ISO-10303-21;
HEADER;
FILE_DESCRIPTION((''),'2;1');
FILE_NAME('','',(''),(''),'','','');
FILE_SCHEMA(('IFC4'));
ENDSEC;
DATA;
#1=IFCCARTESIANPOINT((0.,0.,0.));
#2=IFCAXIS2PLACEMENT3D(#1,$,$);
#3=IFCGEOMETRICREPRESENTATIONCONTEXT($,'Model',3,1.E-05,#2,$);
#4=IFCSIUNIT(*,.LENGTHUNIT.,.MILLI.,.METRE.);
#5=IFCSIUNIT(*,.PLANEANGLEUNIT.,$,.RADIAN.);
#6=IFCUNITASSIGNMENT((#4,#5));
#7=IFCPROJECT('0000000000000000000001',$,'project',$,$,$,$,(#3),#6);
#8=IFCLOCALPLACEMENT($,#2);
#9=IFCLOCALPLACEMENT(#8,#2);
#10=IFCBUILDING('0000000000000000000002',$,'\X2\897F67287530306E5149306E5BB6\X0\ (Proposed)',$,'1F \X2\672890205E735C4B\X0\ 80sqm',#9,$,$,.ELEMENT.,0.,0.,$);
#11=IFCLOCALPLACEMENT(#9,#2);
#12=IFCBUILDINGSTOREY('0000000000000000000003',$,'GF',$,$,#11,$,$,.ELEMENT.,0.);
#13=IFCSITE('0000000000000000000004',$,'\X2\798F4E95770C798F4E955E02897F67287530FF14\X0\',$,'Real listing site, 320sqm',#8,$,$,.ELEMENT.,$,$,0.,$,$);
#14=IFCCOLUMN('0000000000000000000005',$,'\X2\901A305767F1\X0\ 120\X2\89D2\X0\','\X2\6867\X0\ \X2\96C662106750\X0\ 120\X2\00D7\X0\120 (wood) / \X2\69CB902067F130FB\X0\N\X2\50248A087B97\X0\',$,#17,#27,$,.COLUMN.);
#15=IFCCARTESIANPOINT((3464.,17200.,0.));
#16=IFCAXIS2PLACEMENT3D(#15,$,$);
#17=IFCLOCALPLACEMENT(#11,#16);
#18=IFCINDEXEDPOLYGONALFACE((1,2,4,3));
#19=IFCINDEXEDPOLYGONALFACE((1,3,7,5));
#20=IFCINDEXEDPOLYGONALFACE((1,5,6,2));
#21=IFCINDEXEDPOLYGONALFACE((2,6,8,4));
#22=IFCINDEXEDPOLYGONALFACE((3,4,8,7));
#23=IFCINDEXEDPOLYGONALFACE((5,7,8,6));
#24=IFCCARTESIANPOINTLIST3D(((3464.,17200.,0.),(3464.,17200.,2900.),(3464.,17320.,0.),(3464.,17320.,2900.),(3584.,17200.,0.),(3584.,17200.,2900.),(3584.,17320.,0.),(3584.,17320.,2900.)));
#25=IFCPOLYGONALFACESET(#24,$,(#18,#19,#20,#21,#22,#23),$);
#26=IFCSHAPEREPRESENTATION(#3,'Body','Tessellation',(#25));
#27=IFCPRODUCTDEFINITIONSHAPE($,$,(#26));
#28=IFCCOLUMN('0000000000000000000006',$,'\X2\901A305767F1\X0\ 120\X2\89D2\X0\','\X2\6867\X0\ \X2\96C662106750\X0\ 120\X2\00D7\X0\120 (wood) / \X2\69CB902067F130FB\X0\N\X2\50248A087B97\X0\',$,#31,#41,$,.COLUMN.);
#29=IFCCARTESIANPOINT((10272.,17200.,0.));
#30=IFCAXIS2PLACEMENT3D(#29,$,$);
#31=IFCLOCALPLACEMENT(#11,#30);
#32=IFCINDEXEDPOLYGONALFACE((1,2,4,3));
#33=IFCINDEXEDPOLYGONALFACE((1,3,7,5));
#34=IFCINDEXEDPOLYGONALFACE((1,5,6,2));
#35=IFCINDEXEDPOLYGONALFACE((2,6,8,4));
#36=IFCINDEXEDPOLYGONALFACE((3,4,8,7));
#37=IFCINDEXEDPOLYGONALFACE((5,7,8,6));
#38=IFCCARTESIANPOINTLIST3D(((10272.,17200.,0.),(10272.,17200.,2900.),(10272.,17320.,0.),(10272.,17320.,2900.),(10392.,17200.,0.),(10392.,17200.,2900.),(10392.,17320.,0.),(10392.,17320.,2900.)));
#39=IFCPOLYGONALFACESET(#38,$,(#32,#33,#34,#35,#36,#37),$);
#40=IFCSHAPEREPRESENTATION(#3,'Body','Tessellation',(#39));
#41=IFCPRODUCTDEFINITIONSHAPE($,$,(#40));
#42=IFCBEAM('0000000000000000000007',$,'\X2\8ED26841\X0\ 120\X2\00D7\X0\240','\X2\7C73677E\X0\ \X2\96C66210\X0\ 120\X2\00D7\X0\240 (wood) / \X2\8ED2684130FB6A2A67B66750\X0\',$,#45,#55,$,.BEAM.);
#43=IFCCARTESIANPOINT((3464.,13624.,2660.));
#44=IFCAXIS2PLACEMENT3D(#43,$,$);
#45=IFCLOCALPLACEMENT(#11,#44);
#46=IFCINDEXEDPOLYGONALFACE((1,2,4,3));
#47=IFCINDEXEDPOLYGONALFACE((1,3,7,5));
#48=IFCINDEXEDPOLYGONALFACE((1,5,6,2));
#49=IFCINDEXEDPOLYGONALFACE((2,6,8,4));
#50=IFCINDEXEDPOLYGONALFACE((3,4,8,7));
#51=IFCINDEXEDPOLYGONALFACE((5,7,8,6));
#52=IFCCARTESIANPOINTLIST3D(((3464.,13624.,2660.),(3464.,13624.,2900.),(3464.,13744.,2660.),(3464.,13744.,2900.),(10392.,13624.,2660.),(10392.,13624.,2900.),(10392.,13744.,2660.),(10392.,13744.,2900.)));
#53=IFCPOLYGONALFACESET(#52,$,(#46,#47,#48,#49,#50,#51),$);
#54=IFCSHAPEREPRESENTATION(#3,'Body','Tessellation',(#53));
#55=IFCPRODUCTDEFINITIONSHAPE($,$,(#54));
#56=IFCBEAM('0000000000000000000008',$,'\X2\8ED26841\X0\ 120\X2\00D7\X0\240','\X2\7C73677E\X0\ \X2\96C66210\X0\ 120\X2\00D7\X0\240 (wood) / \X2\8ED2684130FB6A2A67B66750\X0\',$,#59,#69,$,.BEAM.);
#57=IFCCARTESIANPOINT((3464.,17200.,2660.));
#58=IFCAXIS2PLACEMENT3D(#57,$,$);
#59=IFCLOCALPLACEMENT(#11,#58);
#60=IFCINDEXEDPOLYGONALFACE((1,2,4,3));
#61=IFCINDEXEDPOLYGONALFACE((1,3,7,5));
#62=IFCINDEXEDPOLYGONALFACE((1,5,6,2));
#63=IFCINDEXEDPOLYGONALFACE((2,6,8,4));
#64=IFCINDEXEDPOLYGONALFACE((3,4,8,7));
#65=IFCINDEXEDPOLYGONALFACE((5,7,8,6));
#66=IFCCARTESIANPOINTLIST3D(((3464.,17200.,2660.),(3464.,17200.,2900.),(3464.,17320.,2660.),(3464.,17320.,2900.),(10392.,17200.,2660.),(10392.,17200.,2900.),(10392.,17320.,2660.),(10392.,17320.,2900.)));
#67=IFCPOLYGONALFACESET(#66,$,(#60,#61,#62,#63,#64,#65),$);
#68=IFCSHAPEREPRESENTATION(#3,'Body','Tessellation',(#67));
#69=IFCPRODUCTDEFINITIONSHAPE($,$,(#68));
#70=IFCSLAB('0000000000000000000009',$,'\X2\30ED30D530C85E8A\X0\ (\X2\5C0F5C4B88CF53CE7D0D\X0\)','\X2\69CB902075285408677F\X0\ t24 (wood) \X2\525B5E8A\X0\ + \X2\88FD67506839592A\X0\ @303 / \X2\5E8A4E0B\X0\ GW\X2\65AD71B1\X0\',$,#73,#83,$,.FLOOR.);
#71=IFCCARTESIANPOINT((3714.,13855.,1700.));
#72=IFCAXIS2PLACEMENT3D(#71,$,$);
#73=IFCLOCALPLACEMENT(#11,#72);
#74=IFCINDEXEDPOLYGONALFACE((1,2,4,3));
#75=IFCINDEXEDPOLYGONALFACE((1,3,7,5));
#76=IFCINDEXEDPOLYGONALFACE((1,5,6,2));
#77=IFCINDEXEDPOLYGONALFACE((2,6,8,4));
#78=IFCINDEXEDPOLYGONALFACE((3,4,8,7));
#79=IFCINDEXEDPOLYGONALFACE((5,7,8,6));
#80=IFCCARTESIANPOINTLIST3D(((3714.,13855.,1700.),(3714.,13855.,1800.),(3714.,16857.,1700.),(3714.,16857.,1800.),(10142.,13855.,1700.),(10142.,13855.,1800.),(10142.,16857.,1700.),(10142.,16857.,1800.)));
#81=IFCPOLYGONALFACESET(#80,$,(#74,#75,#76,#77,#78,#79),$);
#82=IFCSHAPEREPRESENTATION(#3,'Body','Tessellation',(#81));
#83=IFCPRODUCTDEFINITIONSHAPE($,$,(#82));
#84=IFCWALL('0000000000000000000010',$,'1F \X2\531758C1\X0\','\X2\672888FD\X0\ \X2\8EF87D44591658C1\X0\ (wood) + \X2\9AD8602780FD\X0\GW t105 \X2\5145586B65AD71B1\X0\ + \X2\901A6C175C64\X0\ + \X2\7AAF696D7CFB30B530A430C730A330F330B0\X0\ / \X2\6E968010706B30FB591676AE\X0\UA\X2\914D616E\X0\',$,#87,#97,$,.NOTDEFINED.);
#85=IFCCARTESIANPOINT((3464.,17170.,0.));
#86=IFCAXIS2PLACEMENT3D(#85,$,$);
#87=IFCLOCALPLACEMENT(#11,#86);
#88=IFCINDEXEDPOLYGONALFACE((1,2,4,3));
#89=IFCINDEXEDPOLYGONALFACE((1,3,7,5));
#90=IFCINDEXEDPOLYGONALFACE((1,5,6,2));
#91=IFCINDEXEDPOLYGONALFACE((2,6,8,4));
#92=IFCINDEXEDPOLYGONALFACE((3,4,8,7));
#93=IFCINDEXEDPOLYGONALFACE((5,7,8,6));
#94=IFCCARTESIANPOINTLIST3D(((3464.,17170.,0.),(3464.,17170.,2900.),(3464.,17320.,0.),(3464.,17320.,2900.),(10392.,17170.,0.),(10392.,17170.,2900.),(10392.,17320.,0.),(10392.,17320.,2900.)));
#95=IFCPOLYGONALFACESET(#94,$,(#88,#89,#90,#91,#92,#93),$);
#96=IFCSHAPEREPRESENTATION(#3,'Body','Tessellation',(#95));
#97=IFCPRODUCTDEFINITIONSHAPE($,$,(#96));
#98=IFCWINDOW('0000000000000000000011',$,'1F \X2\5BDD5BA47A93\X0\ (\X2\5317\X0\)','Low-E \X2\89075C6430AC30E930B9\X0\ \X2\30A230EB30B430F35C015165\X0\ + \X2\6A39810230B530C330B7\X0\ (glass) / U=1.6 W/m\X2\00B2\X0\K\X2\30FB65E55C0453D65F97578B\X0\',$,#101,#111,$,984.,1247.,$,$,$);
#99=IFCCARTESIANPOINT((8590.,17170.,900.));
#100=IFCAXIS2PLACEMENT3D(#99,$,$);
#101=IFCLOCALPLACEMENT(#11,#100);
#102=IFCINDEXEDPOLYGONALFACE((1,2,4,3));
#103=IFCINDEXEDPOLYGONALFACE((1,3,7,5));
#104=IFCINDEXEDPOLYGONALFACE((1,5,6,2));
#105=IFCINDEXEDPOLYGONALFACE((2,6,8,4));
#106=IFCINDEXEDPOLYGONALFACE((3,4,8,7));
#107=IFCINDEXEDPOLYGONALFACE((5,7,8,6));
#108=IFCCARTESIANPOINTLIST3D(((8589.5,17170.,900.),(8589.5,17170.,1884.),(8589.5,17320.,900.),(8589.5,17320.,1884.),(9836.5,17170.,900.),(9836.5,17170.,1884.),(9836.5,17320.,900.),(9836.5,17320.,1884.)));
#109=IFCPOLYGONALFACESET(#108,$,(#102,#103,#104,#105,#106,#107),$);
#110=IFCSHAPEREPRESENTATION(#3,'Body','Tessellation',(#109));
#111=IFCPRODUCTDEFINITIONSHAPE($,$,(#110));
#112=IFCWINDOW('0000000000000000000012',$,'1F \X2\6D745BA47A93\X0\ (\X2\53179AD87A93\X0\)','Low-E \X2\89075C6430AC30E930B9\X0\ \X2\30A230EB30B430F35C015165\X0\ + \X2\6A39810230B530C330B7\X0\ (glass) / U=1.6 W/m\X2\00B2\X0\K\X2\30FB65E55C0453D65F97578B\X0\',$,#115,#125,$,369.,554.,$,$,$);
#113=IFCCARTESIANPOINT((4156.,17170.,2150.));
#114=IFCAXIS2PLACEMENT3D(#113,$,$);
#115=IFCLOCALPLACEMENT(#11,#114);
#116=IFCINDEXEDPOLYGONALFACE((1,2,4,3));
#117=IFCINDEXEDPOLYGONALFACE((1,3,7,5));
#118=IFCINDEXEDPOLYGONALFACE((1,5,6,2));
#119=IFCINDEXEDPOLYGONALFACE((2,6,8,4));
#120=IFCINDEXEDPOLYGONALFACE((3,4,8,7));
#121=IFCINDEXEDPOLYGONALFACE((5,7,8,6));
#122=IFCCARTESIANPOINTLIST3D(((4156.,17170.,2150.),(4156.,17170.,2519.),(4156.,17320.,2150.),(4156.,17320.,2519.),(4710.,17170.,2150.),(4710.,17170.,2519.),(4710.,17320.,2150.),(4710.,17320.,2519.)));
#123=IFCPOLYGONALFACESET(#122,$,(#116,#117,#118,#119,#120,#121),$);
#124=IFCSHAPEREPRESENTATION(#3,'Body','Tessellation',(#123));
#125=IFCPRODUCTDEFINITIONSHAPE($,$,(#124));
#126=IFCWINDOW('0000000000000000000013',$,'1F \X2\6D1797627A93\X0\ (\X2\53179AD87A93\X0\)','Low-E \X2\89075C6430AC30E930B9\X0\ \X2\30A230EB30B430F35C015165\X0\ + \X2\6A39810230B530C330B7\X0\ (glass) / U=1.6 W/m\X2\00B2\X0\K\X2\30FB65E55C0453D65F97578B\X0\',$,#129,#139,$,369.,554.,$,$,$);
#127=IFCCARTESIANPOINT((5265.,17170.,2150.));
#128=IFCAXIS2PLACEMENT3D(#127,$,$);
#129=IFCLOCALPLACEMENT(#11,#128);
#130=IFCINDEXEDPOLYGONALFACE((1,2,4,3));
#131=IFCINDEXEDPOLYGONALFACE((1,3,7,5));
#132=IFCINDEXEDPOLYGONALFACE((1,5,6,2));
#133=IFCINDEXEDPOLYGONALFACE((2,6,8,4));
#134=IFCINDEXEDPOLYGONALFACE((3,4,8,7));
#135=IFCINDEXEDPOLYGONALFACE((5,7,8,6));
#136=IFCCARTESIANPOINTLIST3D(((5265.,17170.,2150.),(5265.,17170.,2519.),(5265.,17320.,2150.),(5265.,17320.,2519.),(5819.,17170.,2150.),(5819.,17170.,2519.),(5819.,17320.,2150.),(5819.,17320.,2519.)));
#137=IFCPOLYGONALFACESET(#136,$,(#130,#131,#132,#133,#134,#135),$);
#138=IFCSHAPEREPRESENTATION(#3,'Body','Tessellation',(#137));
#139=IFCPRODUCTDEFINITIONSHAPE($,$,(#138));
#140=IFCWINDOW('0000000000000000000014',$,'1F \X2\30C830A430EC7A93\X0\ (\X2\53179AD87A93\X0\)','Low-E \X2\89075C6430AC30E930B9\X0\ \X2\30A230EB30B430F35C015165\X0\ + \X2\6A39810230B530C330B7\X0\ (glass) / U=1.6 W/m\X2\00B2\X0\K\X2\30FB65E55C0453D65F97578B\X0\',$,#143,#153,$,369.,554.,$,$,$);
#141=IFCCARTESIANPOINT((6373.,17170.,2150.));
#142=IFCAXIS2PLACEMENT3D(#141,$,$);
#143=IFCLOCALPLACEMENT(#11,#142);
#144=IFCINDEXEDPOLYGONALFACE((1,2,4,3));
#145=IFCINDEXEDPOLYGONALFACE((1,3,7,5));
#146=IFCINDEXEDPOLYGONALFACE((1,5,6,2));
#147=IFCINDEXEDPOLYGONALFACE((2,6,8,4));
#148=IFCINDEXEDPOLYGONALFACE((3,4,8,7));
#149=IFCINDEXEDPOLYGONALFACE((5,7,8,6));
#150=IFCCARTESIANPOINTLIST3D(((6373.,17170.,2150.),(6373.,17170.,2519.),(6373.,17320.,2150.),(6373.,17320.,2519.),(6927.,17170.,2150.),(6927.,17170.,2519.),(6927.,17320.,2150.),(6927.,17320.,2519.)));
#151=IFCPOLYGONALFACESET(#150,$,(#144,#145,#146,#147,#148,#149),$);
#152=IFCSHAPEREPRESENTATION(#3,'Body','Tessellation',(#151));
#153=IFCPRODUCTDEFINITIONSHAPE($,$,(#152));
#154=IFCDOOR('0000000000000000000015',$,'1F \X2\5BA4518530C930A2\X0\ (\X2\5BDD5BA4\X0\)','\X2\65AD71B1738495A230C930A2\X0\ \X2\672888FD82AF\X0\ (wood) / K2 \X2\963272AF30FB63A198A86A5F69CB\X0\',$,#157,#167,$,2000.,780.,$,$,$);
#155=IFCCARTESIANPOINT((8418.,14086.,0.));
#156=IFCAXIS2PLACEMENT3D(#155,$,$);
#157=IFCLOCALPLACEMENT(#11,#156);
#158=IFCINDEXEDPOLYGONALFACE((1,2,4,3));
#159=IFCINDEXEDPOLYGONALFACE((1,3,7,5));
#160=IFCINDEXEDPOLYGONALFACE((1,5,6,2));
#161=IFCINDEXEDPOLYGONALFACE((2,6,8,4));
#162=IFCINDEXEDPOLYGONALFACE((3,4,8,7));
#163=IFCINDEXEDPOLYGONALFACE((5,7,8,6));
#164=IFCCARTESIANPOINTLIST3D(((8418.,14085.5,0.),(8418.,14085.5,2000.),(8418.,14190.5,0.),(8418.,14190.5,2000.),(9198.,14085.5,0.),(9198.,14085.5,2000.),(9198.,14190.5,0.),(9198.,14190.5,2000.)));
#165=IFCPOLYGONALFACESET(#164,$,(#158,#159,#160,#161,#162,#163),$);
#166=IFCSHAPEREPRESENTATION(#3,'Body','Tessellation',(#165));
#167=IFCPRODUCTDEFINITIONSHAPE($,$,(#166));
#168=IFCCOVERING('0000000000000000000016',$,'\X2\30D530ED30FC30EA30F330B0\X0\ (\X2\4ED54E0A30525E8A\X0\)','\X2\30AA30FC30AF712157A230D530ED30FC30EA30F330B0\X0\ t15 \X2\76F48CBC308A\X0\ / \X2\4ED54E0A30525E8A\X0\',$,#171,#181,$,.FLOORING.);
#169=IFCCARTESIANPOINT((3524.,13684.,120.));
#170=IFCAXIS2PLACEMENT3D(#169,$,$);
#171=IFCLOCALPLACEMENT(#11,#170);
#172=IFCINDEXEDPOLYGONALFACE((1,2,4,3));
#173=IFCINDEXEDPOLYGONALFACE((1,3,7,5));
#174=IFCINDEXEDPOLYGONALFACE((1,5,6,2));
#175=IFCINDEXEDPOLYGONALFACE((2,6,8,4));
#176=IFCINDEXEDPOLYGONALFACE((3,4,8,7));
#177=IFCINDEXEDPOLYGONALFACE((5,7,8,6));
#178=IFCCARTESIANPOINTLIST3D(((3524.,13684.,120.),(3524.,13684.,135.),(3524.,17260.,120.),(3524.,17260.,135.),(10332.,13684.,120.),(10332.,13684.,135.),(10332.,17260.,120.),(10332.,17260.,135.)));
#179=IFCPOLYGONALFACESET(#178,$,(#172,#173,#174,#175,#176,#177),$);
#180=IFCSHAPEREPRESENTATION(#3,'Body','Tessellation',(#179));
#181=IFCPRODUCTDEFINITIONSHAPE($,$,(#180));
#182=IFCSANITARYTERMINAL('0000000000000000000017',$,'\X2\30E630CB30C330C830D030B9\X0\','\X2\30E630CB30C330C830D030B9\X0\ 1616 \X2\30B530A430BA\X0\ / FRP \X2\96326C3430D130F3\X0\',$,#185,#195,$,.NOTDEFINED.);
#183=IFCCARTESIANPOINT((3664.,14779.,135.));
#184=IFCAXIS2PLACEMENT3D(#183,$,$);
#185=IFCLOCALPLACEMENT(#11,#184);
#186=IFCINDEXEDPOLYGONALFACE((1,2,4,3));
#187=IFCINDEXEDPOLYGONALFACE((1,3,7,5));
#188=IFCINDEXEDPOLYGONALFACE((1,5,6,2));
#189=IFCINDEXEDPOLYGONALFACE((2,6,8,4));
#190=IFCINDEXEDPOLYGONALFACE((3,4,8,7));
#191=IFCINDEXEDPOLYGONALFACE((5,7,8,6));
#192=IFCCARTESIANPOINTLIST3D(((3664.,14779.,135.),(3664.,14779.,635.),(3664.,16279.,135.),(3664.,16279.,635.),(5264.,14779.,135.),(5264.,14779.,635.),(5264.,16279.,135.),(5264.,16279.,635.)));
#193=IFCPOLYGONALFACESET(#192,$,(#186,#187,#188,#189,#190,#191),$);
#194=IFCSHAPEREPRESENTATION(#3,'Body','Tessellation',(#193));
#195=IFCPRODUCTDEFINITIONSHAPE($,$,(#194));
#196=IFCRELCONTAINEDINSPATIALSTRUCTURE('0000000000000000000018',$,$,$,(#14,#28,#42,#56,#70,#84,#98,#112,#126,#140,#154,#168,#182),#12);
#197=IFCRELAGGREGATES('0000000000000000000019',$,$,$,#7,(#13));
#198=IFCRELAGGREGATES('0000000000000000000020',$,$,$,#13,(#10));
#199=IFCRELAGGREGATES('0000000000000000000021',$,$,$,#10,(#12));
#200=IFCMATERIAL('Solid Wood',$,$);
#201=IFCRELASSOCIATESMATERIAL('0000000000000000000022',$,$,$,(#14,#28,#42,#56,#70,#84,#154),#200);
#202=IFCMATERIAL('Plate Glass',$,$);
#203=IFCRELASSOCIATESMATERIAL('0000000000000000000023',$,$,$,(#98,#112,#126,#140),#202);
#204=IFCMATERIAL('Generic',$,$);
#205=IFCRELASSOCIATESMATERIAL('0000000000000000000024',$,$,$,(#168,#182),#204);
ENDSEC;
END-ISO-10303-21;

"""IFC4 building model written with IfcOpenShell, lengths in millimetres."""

from ifc_helpers import new_model, si_unit, frame, frame_2d, origin, place, context, project, spatial, rectangle, extrude, material, element, fill, save


model = new_model("IFC4")

# Units and contexts
model_context = context("Model", 3, precision=1e-05, world=origin())
ifc_project = project(units=[si_unit("LENGTHUNIT", "METRE", prefix="MILLI"), si_unit("PLANEANGLEUNIT", "RADIAN")], contexts=[model_context])

# Site, building, storey
site_placement = place(None, origin())
site = spatial("IfcSite", under=ifc_project, at=site_placement, Name="福井県福井市西木田４", ObjectType="Real listing site, 320sqm", CompositionType="ELEMENT", RefElevation=0.0)
building_placement = place(site_placement, origin())
building = spatial("IfcBuilding", under=site, at=building_placement, Name="西木田の光の家 (Proposed)", ObjectType="1F 木造平屋 80sqm", CompositionType="ELEMENT", ElevationOfRefHeight=0.0, ElevationOfTerrain=0.0)
storey_placement = place(building_placement, origin())
storey = spatial("IfcBuildingStorey", under=building, at=storey_placement, Name="GF", CompositionType="ELEMENT", Elevation=0.0)

# Columns
ifc_material_1 = material(Name="Solid Wood")
column_1_placement = place(storey_placement, frame((3464.0, 17200.0, 0.0)))
element("IfcColumn", 1, at=column_1_placement, inside=storey, material=ifc_material_1, Name="通し柱 120角", Description="桧 集成材 120×120 (wood) / 構造柱・N値計算", PredefinedType="COLUMN", context=model_context, shape_type="SweptSolid", body=[
    extrude(rectangle(XDim=120.0, YDim=120.0, at=frame_2d((60.0, 60.0))), frame((3464.0, 17200.0, 0.0)), (0.0, 0.0, 1.0), 2900.0),
])
column_2_placement = place(storey_placement, frame((10272.0, 17200.0, 0.0)))
element("IfcColumn", 2, at=column_2_placement, inside=storey, material=ifc_material_1, Name="通し柱 120角", Description="桧 集成材 120×120 (wood) / 構造柱・N値計算", PredefinedType="COLUMN", context=model_context, shape_type="SweptSolid", body=[
    extrude(rectangle(XDim=120.0, YDim=120.0, at=frame_2d((60.0, 60.0))), frame((10272.0, 17200.0, 0.0)), (0.0, 0.0, 1.0), 2900.0),
])

# Beams
beam_1_placement = place(storey_placement, frame((3464.0, 13624.0, 2660.0)))
element("IfcBeam", 3, at=beam_1_placement, inside=storey, material=ifc_material_1, Name="軒桁 120×240", Description="米松 集成 120×240 (wood) / 軒桁・横架材", PredefinedType="BEAM", context=model_context, shape_type="SweptSolid", body=[
    extrude(rectangle(XDim=6928.0, YDim=120.0, at=frame_2d((3464.0, 60.0))), frame((3464.0, 13624.0, 2660.0)), (0.0, 0.0, 1.0), 240.0),
])
beam_2_placement = place(storey_placement, frame((3464.0, 17200.0, 2660.0)))
element("IfcBeam", 4, at=beam_2_placement, inside=storey, material=ifc_material_1, Name="軒桁 120×240", Description="米松 集成 120×240 (wood) / 軒桁・横架材", PredefinedType="BEAM", context=model_context, shape_type="SweptSolid", body=[
    extrude(rectangle(XDim=6928.0, YDim=120.0, at=frame_2d((3464.0, 60.0))), frame((3464.0, 17200.0, 2660.0)), (0.0, 0.0, 1.0), 240.0),
])

# Slab
slab_placement = place(storey_placement, frame((3714.0, 13855.0, 1700.0)))
element("IfcSlab", 5, at=slab_placement, inside=storey, material=ifc_material_1, Name="ロフト床 (小屋裏収納)", Description="構造用合板 t24 (wood) 剛床 + 製材根太 @303 / 床下 GW断熱", PredefinedType="FLOOR", context=model_context, shape_type="SweptSolid", body=[
    extrude(rectangle(XDim=6428.0, YDim=3002.0, at=frame_2d((3214.0, 1501.0))), frame((3714.0, 13855.0, 1700.0)), (0.0, 0.0, 1.0), 100.0),
])

# Wall, openings, windows
wall_1_placement = place(storey_placement, frame((3464.0, 17170.0, 0.0)))
wall_1 = element("IfcWall", 6, at=wall_1_placement, inside=storey, material=ifc_material_1, Name="1F 北壁", Description="木製 軸組外壁 (wood) + 高性能GW t105 充填断熱 + 通気層 + 窯業系サイディング / 準耐火・外皮UA配慮", PredefinedType="NOTDEFINED", context=model_context, shape_type="SweptSolid", body=[
    extrude(rectangle(XDim=6928.0, YDim=150.0, at=frame_2d((3464.0, 75.0))), frame((3464.0, 17170.0, 0.0)), (0.0, 0.0, 1.0), 2900.0),
])
opening_1_placement = place(storey_placement, frame((8590.0, 17170.0, 900.0)))
opening_1 = element("IfcOpeningElement", 7, at=opening_1_placement, cuts=wall_1, PredefinedType="NOTDEFINED", context=model_context, shape_type="SweptSolid", body=[
    extrude(rectangle(XDim=1247.0, YDim=150.0, at=frame_2d((623.0, 75.0))), frame((8590.0, 17170.0, 900.0)), (0.0, 0.0, 1.0), 984.0),
])
opening_2_placement = place(storey_placement, frame((4156.0, 17170.0, 2150.0)))
opening_2 = element("IfcOpeningElement", 8, at=opening_2_placement, cuts=wall_1, PredefinedType="NOTDEFINED", context=model_context, shape_type="SweptSolid", body=[
    extrude(rectangle(XDim=554.0, YDim=150.0, at=frame_2d((277.0, 75.0))), frame((4156.0, 17170.0, 2150.0)), (0.0, 0.0, 1.0), 369.0),
])
opening_3_placement = place(storey_placement, frame((5265.0, 17170.0, 2150.0)))
opening_3 = element("IfcOpeningElement", 9, at=opening_3_placement, cuts=wall_1, PredefinedType="NOTDEFINED", context=model_context, shape_type="SweptSolid", body=[
    extrude(rectangle(XDim=554.0, YDim=150.0, at=frame_2d((277.0, 75.0))), frame((5265.0, 17170.0, 2150.0)), (0.0, 0.0, 1.0), 369.0),
])
opening_4_placement = place(storey_placement, frame((6373.0, 17170.0, 2150.0)))
opening_4 = element("IfcOpeningElement", 10, at=opening_4_placement, cuts=wall_1, PredefinedType="NOTDEFINED", context=model_context, shape_type="SweptSolid", body=[
    extrude(rectangle(XDim=554.0, YDim=150.0, at=frame_2d((277.0, 75.0))), frame((6373.0, 17170.0, 2150.0)), (0.0, 0.0, 1.0), 369.0),
])
ifc_material_2 = material(Name="Plate Glass")
window_1_placement = place(storey_placement, frame((8590.0, 17170.0, 900.0)))
window_1 = element("IfcWindow", 11, at=window_1_placement, inside=storey, material=ifc_material_2, Name="1F 寝室窓 (北)", Description="Low-E 複層ガラス アルゴン封入 + 樹脂サッシ (glass) / U=1.6 W/m²K・日射取得型", OverallHeight=984.0, OverallWidth=1247.0, context=model_context, shape_type="SweptSolid", body=[
    extrude(rectangle(XDim=1247.0, YDim=150.0, at=frame_2d((623.0, 75.0))), frame((8590.0, 17170.0, 900.0)), (0.0, 0.0, 1.0), 984.0),
])
fill(opening_1, window_1)
window_2_placement = place(storey_placement, frame((4156.0, 17170.0, 2150.0)))
window_2 = element("IfcWindow", 12, at=window_2_placement, inside=storey, material=ifc_material_2, Name="1F 浴室窓 (北高窓)", Description="Low-E 複層ガラス アルゴン封入 + 樹脂サッシ (glass) / U=1.6 W/m²K・日射取得型", OverallHeight=369.0, OverallWidth=554.0, context=model_context, shape_type="SweptSolid", body=[
    extrude(rectangle(XDim=554.0, YDim=150.0, at=frame_2d((277.0, 75.0))), frame((4156.0, 17170.0, 2150.0)), (0.0, 0.0, 1.0), 369.0),
])
fill(opening_2, window_2)
window_3_placement = place(storey_placement, frame((5265.0, 17170.0, 2150.0)))
window_3 = element("IfcWindow", 13, at=window_3_placement, inside=storey, material=ifc_material_2, Name="1F 洗面窓 (北高窓)", Description="Low-E 複層ガラス アルゴン封入 + 樹脂サッシ (glass) / U=1.6 W/m²K・日射取得型", OverallHeight=369.0, OverallWidth=554.0, context=model_context, shape_type="SweptSolid", body=[
    extrude(rectangle(XDim=554.0, YDim=150.0, at=frame_2d((277.0, 75.0))), frame((5265.0, 17170.0, 2150.0)), (0.0, 0.0, 1.0), 369.0),
])
fill(opening_3, window_3)
window_4_placement = place(storey_placement, frame((6373.0, 17170.0, 2150.0)))
window_4 = element("IfcWindow", 14, at=window_4_placement, inside=storey, material=ifc_material_2, Name="1F トイレ窓 (北高窓)", Description="Low-E 複層ガラス アルゴン封入 + 樹脂サッシ (glass) / U=1.6 W/m²K・日射取得型", OverallHeight=369.0, OverallWidth=554.0, context=model_context, shape_type="SweptSolid", body=[
    extrude(rectangle(XDim=554.0, YDim=150.0, at=frame_2d((277.0, 75.0))), frame((6373.0, 17170.0, 2150.0)), (0.0, 0.0, 1.0), 369.0),
])
fill(opening_4, window_4)

# Door
door_1_placement = place(storey_placement, frame((8418.0, 14086.0, 0.0)))
element("IfcDoor", 15, at=door_1_placement, inside=storey, material=ifc_material_1, Name="1F 室内ドア (寝室)", Description="断熱玄関ドア 木製芯 (wood) / K2 防犯・採風機構", OverallHeight=2000.0, OverallWidth=780.0, context=model_context, shape_type="SweptSolid", body=[
    extrude(rectangle(XDim=780.0, YDim=105.0, at=frame_2d((390.0, 52.0))), frame((8418.0, 14086.0, 0.0)), (0.0, 0.0, 1.0), 2000.0),
])

# Covering
ifc_material_3 = material(Name="Generic")
covering_placement = place(storey_placement, frame((3524.0, 13684.0, 120.0)))
element("IfcCovering", 16, at=covering_placement, inside=storey, material=ifc_material_3, Name="フローリング (仕上げ床)", Description="オーク無垢フローリング t15 直貼り / 仕上げ床", PredefinedType="FLOORING", context=model_context, shape_type="SweptSolid", body=[
    extrude(rectangle(XDim=6808.0, YDim=3576.0, at=frame_2d((3404.0, 1788.0))), frame((3524.0, 13684.0, 120.0)), (0.0, 0.0, 1.0), 15.0),
])

# Sanitary terminal
sanitary_terminal_1_placement = place(storey_placement, frame((3664.0, 14779.0, 135.0)))
element("IfcSanitaryTerminal", 17, at=sanitary_terminal_1_placement, inside=storey, material=ifc_material_3, Name="ユニットバス", Description="ユニットバス 1616 サイズ / FRP 防水パン", PredefinedType="NOTDEFINED", context=model_context, shape_type="SweptSolid", body=[
    extrude(rectangle(XDim=1600.0, YDim=1500.0, at=frame_2d((800.0, 750.0))), frame((3664.0, 14779.0, 135.0)), (0.0, 0.0, 1.0), 500.0),
])

save(model, "model.ifc")
